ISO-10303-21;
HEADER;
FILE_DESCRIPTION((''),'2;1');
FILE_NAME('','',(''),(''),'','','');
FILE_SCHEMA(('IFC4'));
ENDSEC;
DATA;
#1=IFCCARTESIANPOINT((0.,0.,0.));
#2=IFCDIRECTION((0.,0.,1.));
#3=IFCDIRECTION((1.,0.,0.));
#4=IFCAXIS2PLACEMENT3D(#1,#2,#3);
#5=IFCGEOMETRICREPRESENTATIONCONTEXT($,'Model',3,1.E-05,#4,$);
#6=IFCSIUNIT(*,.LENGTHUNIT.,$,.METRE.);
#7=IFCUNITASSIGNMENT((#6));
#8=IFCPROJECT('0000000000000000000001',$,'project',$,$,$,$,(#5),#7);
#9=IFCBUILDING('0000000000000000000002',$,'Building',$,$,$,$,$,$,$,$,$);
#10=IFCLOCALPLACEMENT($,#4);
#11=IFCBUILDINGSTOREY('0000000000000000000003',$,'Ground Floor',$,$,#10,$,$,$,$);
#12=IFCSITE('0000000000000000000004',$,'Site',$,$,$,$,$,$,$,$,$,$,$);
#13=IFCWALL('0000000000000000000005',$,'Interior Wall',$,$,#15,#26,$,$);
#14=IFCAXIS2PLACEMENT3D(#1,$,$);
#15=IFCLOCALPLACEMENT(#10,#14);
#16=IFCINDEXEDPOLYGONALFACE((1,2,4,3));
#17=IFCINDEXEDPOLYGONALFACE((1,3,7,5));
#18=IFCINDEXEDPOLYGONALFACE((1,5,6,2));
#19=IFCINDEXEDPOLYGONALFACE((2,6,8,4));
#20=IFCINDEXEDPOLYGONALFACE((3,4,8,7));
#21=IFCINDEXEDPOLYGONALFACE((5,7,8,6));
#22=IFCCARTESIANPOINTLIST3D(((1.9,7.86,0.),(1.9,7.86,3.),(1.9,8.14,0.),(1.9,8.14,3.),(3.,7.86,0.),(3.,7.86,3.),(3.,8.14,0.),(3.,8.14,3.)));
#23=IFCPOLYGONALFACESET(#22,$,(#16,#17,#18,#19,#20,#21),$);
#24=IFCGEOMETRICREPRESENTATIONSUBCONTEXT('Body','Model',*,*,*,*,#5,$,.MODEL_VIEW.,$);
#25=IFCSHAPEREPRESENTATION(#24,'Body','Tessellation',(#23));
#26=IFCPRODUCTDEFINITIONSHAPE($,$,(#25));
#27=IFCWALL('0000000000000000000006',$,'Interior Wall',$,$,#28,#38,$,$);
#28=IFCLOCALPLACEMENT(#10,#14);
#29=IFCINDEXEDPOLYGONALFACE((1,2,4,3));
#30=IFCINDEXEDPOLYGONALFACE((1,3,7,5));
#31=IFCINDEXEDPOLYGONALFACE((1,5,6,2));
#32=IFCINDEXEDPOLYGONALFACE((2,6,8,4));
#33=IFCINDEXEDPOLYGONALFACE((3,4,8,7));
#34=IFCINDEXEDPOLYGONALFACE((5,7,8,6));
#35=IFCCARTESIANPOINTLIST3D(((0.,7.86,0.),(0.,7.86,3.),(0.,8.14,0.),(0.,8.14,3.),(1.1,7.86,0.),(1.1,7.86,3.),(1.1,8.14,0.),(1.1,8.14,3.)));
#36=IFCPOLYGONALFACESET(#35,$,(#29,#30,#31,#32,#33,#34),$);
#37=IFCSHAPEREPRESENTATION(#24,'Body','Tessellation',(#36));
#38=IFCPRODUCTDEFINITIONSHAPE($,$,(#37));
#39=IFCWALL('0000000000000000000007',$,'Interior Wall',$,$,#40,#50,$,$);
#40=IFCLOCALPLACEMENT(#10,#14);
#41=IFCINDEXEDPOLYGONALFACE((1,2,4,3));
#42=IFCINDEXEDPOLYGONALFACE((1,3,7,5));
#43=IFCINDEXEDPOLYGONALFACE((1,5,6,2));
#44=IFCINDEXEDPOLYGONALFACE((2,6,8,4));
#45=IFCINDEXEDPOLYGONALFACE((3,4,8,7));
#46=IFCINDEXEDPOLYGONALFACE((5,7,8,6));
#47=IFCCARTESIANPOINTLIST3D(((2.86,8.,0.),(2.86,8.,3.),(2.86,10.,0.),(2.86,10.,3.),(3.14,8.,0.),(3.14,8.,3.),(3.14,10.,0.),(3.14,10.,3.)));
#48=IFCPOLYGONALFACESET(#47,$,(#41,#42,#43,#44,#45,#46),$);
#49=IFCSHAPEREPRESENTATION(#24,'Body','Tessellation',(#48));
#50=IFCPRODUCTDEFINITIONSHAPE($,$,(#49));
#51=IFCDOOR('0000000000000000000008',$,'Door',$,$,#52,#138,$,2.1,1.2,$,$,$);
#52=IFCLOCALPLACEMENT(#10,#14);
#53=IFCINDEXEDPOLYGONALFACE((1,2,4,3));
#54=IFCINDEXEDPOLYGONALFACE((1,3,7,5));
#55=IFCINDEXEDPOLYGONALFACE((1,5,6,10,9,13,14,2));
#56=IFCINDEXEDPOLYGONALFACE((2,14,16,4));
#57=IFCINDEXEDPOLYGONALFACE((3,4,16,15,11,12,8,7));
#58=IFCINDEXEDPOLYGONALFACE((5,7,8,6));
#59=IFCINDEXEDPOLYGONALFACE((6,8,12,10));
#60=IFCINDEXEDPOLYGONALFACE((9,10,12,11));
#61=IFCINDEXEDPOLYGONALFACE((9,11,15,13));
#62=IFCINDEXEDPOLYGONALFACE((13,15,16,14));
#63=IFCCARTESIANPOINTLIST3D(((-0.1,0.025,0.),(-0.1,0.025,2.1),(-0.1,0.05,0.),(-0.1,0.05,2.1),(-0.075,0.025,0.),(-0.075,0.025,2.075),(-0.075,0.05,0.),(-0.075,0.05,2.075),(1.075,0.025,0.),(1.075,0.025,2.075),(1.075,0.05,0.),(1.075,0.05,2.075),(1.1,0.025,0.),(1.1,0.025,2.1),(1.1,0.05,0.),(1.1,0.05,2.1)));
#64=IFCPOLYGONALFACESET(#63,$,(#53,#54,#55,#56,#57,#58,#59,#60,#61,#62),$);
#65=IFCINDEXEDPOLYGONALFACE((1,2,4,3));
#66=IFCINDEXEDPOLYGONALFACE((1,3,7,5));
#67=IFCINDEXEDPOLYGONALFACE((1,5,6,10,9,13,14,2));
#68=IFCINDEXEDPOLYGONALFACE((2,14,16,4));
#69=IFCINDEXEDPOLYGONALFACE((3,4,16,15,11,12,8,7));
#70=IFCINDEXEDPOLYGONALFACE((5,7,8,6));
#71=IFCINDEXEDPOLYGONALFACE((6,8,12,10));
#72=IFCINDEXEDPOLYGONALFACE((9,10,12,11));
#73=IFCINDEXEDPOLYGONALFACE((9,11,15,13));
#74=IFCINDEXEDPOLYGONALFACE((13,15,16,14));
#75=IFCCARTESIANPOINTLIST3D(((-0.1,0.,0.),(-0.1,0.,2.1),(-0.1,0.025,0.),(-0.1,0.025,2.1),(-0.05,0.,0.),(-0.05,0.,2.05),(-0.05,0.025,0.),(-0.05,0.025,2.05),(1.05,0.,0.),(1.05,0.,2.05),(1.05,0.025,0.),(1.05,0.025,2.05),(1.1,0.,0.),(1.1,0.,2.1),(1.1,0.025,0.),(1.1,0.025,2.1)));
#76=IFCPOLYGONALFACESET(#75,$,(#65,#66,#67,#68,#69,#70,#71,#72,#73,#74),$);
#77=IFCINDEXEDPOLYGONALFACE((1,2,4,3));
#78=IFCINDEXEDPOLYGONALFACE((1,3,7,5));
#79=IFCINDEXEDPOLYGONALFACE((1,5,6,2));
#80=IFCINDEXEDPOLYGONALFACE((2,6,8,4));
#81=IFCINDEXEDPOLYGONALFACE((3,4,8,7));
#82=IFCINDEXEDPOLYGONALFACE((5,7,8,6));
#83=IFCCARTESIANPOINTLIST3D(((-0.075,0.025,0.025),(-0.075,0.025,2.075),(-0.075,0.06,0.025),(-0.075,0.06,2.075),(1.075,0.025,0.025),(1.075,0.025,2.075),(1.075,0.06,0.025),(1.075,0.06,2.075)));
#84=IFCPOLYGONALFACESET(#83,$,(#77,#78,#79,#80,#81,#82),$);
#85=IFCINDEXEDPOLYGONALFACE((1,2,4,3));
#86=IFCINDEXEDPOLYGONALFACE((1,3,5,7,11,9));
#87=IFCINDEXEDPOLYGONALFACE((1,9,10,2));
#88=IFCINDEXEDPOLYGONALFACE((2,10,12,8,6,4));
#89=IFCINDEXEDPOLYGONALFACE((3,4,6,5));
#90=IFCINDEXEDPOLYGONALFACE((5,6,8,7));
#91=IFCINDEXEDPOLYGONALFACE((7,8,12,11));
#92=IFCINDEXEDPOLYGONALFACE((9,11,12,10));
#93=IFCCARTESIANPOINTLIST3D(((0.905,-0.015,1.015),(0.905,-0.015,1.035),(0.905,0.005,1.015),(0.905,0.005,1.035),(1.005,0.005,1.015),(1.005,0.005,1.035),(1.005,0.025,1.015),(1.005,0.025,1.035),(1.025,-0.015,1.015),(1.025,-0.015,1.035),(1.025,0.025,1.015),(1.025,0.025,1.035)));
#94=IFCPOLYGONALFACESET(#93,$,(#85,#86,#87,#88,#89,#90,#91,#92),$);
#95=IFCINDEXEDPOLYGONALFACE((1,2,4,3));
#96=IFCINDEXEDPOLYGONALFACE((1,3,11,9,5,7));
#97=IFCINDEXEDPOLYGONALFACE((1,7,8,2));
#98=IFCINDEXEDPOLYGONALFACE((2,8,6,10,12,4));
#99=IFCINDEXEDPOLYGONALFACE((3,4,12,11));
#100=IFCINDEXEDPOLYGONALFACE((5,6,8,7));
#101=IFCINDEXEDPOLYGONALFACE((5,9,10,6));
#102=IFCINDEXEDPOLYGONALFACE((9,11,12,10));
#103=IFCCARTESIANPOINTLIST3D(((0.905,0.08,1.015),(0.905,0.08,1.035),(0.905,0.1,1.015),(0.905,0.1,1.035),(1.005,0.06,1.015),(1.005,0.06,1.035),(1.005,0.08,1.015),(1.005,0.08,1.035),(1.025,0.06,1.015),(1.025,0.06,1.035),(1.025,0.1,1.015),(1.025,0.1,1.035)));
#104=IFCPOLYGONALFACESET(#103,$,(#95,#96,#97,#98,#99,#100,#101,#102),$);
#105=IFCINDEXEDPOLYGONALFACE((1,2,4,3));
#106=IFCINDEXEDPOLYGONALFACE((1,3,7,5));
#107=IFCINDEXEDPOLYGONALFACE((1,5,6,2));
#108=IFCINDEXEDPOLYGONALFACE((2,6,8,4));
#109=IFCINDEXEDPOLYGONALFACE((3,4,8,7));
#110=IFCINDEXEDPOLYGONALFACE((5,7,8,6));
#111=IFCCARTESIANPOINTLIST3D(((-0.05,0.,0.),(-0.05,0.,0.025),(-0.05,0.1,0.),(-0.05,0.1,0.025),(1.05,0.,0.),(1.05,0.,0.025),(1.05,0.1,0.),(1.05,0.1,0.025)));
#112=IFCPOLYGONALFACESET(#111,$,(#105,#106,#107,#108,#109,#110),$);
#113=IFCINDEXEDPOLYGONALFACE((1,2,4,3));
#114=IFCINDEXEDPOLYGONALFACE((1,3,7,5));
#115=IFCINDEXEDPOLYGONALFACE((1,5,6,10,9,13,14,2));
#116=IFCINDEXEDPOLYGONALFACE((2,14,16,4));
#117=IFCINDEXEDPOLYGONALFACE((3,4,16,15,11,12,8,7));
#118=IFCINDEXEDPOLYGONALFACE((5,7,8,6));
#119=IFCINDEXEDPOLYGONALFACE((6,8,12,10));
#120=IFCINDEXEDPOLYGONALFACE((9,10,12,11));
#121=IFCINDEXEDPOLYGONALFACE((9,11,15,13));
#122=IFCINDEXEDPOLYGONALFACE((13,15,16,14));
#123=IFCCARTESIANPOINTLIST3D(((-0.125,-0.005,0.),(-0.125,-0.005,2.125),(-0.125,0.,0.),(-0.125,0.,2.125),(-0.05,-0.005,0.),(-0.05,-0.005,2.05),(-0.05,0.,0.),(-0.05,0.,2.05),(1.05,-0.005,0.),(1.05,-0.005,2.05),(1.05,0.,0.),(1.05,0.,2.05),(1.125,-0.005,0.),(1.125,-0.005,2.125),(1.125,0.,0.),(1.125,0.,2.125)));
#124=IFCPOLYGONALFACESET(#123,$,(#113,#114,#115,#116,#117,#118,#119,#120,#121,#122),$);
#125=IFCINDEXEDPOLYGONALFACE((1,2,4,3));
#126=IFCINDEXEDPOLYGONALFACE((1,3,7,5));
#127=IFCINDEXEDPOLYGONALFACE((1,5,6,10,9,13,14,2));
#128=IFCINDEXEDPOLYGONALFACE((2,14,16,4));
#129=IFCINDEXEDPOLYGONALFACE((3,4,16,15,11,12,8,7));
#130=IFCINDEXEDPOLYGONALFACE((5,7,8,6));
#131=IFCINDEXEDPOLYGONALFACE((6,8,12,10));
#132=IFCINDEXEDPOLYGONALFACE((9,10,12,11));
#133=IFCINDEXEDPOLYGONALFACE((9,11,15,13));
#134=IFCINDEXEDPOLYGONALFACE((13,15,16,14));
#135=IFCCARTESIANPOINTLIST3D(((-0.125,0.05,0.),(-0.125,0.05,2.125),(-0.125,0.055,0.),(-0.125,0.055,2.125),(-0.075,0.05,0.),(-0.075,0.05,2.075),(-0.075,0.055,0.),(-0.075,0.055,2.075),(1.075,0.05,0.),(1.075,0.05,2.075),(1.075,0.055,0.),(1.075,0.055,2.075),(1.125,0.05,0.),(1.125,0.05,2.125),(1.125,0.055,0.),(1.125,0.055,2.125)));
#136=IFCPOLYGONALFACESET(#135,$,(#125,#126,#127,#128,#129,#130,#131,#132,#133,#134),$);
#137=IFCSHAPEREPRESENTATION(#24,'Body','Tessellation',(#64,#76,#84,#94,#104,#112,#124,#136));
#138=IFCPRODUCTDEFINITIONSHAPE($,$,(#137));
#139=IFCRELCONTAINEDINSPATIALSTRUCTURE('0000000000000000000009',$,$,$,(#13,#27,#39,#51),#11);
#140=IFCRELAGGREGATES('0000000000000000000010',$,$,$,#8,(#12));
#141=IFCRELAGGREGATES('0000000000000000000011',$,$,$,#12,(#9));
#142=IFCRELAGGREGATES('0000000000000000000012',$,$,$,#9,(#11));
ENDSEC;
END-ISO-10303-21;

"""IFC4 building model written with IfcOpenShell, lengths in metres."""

from ifc_helpers import new_model, si_unit, frame, origin_with_axes, place, context, subcontext, project, spatial, line, indexed_curve, outline, extrude, element, save


model = new_model("IFC4")

# Units and contexts
model_context = context("Model", 3, precision=1e-05, world=origin_with_axes())
body_context = subcontext(model_context, "Body", "Model", "MODEL_VIEW")
ifc_project = project(units=[si_unit("LENGTHUNIT", "METRE")], contexts=[model_context])

# Site, building, storey
site = spatial("IfcSite", under=ifc_project, Name="Site")
building = spatial("IfcBuilding", under=site, Name="Building")
storey_placement = place(None, origin_with_axes())
storey = spatial("IfcBuildingStorey", under=building, at=storey_placement, Name="Ground Floor")

# Walls
for number, where, z_axis, x_axis, name in (
    (1, (3.0, 8.0, 0.0), (0.0, 0.0, 1.0), (-1.0, 0.0, 0.0), "Interior Wall"),
    (2, (1.1, 8.0, 0.0), (0.0, 0.0, 1.0), (-1.0, 0.0, 0.0), "Interior Wall"),
):
    element("IfcWall", number, at=place(storey_placement, frame(where, z_axis=z_axis, x_axis=x_axis)), inside=storey, Name=name, context=body_context, shape_type="SweptSolid", body=[
        extrude(outline(indexed_curve([(0.0, 0.0), (0.0, 0.28), (1.1, 0.28), (1.1, 0.0), (0.0, 0.0)], self_intersect=False)), frame((0.0, -0.14, 0.0), z_axis=(0.0, 0.0, 1.0), x_axis=(1.0, 0.0, 0.0)), (0.0, 0.0, 1.0), 3.0),
    ])
wall_1_placement = place(storey_placement, frame((3.0, 8.0, 0.0), z_axis=(0.0, 0.0, 1.0), x_axis=(0.0, 1.0, 0.0)))
element("IfcWall", 3, at=wall_1_placement, inside=storey, Name="Interior Wall", context=body_context, shape_type="SweptSolid", body=[
    extrude(outline(indexed_curve([(0.0, 0.0), (0.0, 0.28), (2.0, 0.28), (2.0, 0.0), (0.0, 0.0)], self_intersect=False)), frame((0.0, -0.14, 0.0), z_axis=(0.0, 0.0, 1.0), x_axis=(1.0, 0.0, 0.0)), (0.0, 0.0, 1.0), 3.0),
])

# Door
door_1_placement = place(storey_placement, frame((-0.1, 0.0, 0.0), z_axis=(0.0, 0.0, 1.0), x_axis=(1.0, 0.0, 0.0)))
element("IfcDoor", 4, at=door_1_placement, inside=storey, Name="Door", OverallHeight=2.1, OverallWidth=1.2, context=body_context, shape_type="SweptSolid", body=[
    extrude(outline(indexed_curve([(0.0, 0.0), (0.0, 2.1), (1.2, 2.1), (1.2, 0.0), (1.175, 0.0), (1.175, 2.075), (0.025, 2.075), (0.025, 0.0)], segments=[line(1, 2, 3, 4, 5, 6, 7, 8, 1)])), frame((0.0, 0.025, 0.0), z_axis=(0.0, -1.0, 0.0), x_axis=(1.0, 0.0, 0.0)), (0.0, 0.0, -1.0), 0.025),
    extrude(outline(indexed_curve([(0.0, 0.0), (0.0, 2.1), (1.2, 2.1), (1.2, 0.0), (1.15, 0.0), (1.15, 2.05), (0.05, 2.05), (0.05, 0.0)], segments=[line(1, 2, 3, 4, 5, 6, 7, 8, 1)])), frame((0.0, 0.0, 0.0), z_axis=(0.0, -1.0, 0.0), x_axis=(1.0, 0.0, 0.0)), (0.0, 0.0, -1.0), 0.025),
    extrude(outline(indexed_curve([(0.0, 0.0), (1.15, 0.0), (1.15, 0.035), (0.0, 0.035)], segments=[line(1, 2, 3, 4, 1)])), frame((0.025, 0.025, 0.025), z_axis=(0.0, 0.0, 1.0), x_axis=(1.0, 0.0, 0.0)), (0.0, 0.0, 1.0), 2.05),
    extrude(outline(indexed_curve([(0.0, 0.0), (0.0, -0.04), (-0.12, -0.04), (-0.12, -0.02), (-0.02, -0.02), (-0.02, 0.0)], segments=[line(1, 2, 3, 4, 5, 6, 1)])), frame((1.125, 0.025, 1.015), z_axis=(0.0, 0.0, 1.0), x_axis=(1.0, 0.0, 0.0)), (0.0, 0.0, 1.0), 0.02),
    extrude(outline(indexed_curve([(0.0, 0.0), (0.0, 0.04), (-0.12, 0.04), (-0.12, 0.02), (-0.02, 0.02), (-0.02, 0.0)], segments=[line(1, 2, 3, 4, 5, 6, 1)])), frame((1.125, 0.06, 1.015), z_axis=(0.0, 0.0, 1.0), x_axis=(1.0, 0.0, 0.0)), (0.0, 0.0, 1.0), 0.02),
    extrude(outline(indexed_curve([(0.0, 0.0), (1.1, 0.0), (1.1, 0.1), (0.0, 0.1)], segments=[line(1, 2, 3, 4, 1)])), frame((0.05, 0.0, 0.0), z_axis=(0.0, 0.0, 1.0), x_axis=(1.0, 0.0, 0.0)), (0.0, 0.0, 1.0), 0.025),
    extrude(outline(indexed_curve([(0.0, 0.0), (0.0, 2.125), (1.25, 2.125), (1.25, 0.0), (1.175, 0.0), (1.175, 2.05), (0.075, 2.05), (0.075, 0.0)], segments=[line(1, 2, 3, 4, 5, 6, 7, 8, 1)])), frame((-0.025, -0.005, 0.0), z_axis=(0.0, -1.0, 0.0), x_axis=(1.0, 0.0, 0.0)), (0.0, 0.0, -1.0), 0.005),
    extrude(outline(indexed_curve([(0.0, 0.0), (0.0, 2.125), (1.25, 2.125), (1.25, 0.0), (1.2, 0.0), (1.2, 2.075), (0.05, 2.075), (0.05, 0.0)], segments=[line(1, 2, 3, 4, 5, 6, 7, 8, 1)])), frame((-0.025, 0.05, 0.0), z_axis=(0.0, -1.0, 0.0), x_axis=(1.0, 0.0, 0.0)), (0.0, 0.0, -1.0), 0.005),
])

save(model, "model.ifc")
